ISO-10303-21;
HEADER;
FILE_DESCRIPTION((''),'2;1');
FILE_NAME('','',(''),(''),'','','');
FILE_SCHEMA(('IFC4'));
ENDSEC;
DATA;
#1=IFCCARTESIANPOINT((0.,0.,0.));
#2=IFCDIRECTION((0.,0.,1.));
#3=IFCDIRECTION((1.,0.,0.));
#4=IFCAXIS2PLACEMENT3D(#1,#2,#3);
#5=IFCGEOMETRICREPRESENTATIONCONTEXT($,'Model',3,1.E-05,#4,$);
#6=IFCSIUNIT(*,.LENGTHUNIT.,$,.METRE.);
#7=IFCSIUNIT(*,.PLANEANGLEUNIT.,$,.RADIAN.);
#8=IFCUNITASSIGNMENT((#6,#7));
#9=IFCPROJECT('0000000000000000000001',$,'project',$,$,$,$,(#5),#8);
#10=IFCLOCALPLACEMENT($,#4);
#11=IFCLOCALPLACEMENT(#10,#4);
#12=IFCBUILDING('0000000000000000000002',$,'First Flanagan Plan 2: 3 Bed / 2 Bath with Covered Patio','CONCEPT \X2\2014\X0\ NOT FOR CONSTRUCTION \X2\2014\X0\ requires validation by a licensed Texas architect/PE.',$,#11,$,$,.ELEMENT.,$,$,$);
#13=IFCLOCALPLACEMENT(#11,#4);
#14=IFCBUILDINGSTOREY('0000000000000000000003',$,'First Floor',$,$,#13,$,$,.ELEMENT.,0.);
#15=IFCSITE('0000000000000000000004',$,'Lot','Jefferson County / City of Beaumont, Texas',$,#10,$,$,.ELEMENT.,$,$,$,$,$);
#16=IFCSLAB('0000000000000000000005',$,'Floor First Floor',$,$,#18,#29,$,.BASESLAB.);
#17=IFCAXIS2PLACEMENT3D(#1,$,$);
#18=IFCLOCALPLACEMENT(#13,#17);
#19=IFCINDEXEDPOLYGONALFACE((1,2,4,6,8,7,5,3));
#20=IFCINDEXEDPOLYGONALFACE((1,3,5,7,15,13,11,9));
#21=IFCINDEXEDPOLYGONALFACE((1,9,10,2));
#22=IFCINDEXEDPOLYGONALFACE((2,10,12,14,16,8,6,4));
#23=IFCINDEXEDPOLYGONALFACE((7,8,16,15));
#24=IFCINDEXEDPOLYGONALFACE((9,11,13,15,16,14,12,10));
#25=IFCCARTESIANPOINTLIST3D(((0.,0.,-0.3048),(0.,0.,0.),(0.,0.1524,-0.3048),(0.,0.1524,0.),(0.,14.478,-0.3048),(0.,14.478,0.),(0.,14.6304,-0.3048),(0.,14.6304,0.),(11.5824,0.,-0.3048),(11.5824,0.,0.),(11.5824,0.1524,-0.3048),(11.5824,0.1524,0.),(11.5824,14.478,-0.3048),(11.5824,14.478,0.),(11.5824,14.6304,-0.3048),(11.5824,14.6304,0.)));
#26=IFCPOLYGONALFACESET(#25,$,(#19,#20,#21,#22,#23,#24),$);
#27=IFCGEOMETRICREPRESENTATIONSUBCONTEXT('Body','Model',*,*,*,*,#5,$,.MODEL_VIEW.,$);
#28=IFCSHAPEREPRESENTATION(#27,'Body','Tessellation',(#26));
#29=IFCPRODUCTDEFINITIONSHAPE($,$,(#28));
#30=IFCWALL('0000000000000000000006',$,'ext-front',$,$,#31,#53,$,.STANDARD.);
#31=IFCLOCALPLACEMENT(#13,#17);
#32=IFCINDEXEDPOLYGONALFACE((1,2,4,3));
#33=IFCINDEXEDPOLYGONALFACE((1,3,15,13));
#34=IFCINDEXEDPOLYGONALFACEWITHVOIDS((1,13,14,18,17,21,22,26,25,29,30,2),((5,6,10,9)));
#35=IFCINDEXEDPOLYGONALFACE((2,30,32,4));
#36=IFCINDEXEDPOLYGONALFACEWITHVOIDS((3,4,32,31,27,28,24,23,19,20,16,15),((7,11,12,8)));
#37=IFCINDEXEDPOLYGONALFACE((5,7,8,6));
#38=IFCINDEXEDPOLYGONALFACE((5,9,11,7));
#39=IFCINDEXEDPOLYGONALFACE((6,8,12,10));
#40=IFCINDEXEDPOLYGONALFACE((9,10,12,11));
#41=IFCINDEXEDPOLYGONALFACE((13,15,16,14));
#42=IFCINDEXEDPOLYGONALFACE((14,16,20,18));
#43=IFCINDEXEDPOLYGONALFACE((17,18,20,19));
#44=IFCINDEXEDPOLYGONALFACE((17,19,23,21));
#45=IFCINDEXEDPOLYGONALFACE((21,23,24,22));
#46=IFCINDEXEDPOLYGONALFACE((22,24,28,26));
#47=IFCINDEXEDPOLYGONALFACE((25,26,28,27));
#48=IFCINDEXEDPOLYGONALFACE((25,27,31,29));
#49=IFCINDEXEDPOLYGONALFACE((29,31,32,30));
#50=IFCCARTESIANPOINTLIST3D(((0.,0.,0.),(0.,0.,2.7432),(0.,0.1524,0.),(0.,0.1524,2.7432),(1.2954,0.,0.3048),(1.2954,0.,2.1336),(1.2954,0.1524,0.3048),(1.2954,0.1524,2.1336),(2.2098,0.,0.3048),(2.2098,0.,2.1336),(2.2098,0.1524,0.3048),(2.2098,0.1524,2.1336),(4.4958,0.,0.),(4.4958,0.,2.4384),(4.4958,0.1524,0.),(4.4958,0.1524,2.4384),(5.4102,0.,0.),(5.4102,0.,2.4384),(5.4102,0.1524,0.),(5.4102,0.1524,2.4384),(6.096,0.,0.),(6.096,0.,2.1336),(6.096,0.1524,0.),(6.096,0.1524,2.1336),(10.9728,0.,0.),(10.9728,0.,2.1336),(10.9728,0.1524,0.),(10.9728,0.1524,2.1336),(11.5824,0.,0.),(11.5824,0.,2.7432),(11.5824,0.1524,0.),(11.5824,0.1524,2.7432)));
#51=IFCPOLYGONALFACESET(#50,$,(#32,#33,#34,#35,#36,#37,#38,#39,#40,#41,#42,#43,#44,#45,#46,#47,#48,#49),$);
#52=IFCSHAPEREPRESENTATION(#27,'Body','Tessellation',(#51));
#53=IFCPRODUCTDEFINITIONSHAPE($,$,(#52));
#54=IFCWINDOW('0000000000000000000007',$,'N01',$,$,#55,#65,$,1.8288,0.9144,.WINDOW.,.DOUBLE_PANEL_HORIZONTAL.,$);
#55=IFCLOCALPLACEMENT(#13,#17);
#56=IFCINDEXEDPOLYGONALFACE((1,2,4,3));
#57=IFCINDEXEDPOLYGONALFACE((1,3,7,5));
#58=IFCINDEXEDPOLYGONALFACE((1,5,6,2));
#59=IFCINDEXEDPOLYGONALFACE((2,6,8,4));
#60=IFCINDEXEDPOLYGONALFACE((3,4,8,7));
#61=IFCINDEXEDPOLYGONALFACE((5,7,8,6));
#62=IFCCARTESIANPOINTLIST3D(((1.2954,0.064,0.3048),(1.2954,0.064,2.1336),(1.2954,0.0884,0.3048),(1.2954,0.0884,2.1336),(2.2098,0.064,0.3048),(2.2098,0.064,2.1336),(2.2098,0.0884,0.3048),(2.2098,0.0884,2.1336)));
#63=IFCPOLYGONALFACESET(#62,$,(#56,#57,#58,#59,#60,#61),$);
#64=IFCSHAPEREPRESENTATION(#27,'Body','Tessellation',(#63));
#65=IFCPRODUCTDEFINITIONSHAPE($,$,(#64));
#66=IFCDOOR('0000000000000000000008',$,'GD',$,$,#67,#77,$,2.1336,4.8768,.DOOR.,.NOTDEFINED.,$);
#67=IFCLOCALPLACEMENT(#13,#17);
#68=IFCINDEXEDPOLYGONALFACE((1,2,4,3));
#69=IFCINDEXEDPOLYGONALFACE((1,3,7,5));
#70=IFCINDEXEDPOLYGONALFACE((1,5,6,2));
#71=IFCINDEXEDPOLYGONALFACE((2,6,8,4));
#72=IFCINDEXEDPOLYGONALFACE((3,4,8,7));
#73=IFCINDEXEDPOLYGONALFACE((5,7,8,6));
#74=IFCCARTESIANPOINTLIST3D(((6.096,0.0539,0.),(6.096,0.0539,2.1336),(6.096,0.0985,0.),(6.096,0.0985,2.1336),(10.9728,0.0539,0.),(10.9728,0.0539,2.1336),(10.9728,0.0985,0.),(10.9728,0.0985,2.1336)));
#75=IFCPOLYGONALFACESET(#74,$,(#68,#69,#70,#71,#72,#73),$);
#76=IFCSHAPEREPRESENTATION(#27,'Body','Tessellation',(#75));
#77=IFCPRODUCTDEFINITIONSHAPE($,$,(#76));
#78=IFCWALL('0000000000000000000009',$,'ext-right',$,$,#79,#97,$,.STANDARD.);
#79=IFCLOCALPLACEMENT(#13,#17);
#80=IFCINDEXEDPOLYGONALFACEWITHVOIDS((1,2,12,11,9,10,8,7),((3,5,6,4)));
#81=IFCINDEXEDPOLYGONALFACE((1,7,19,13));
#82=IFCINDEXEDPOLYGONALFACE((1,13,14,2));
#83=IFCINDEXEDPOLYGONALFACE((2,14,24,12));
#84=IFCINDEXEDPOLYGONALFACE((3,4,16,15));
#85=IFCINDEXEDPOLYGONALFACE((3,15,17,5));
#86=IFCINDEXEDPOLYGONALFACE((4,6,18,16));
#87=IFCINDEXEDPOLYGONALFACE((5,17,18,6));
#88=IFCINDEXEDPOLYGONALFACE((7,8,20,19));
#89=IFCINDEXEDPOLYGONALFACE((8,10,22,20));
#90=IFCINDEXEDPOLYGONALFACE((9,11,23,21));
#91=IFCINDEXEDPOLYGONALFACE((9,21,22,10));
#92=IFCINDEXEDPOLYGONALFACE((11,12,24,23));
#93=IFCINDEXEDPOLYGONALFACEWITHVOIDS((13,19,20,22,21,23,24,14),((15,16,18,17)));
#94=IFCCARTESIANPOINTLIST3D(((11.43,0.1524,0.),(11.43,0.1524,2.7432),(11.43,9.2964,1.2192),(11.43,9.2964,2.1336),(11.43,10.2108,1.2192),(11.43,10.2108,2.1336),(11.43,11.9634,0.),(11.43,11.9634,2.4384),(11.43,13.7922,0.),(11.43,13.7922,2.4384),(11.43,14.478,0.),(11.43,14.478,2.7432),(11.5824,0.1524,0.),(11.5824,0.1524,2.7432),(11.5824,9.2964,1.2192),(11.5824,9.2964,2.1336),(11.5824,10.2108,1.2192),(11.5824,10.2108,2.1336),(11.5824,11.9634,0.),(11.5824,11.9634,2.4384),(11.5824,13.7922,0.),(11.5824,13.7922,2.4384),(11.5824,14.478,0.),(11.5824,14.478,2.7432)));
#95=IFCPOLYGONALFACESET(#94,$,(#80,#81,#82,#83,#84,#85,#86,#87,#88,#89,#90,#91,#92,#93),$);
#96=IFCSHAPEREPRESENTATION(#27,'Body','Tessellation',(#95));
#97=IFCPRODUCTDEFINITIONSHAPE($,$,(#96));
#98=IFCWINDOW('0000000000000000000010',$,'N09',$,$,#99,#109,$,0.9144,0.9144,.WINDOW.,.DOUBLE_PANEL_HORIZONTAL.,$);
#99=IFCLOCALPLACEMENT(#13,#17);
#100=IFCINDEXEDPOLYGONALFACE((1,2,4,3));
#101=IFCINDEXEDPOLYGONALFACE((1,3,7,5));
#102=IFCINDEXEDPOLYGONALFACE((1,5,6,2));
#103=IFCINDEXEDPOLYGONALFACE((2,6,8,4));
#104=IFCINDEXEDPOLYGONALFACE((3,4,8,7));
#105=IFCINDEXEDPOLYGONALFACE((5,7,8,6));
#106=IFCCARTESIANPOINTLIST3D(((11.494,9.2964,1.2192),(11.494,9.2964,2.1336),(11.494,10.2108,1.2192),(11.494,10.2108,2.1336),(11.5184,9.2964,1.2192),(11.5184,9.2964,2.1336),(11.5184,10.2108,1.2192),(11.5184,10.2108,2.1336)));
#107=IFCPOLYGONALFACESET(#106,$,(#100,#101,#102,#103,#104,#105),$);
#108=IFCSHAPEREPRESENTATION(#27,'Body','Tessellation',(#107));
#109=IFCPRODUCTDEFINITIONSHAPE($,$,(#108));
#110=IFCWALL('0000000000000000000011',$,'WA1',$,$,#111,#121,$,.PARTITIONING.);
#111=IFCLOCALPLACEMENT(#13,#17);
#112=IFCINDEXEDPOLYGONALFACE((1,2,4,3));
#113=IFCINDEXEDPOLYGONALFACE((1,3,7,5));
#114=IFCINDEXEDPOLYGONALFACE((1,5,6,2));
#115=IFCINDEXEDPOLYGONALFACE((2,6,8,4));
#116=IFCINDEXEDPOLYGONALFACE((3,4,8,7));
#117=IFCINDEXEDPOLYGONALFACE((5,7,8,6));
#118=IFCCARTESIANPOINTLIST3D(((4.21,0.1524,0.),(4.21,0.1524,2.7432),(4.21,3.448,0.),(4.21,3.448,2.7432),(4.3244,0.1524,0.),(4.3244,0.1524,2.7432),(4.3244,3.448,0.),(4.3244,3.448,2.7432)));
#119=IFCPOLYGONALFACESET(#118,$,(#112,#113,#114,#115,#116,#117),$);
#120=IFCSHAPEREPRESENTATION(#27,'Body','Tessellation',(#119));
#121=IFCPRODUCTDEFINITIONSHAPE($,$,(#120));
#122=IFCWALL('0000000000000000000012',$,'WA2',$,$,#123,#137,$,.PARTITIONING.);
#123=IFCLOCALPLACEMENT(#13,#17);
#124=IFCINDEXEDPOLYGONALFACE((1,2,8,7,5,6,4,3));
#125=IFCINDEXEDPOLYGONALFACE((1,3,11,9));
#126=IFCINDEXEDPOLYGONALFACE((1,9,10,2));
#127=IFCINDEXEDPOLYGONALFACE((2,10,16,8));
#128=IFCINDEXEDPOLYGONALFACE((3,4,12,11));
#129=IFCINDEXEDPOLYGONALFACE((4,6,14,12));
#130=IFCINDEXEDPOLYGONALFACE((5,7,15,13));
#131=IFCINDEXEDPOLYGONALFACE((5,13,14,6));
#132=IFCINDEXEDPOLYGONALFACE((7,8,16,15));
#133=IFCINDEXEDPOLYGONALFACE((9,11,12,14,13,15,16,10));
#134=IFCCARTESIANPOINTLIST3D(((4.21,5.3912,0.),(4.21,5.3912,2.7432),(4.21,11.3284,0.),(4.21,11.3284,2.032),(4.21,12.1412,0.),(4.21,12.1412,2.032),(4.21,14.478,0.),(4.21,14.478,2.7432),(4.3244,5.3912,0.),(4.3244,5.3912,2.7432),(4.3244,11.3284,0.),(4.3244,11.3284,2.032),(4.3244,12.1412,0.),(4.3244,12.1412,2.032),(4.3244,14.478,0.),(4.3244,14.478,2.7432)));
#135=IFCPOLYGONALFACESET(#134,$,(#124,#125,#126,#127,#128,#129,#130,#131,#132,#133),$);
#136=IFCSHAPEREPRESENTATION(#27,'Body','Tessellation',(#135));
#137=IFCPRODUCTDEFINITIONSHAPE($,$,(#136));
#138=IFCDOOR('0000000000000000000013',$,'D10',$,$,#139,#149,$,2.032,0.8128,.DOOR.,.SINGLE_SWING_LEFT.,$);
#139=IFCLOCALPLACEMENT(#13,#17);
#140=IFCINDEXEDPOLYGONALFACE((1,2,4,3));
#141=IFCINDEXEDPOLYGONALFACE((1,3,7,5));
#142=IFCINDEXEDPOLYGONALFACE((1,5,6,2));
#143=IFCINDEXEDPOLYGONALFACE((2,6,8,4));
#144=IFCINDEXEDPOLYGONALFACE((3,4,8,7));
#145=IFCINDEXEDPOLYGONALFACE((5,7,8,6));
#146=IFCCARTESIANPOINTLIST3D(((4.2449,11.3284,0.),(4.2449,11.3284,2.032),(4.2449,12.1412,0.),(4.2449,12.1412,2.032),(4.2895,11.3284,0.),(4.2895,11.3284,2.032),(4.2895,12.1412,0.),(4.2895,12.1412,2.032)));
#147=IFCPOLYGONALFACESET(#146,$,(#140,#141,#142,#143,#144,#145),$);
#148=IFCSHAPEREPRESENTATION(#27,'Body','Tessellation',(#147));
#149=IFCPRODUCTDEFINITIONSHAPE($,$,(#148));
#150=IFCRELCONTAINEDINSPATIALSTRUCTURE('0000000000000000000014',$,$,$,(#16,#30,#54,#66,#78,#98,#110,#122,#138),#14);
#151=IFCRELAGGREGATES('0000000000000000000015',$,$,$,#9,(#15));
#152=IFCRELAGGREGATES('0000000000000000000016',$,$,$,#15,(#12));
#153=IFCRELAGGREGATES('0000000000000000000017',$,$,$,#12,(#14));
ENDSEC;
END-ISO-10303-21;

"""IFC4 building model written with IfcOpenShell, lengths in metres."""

from ifc_helpers import new_model, si_unit, frame, frame_2d, origin_with_axes, place, context, subcontext, project, spatial, polyline, rectangle, outline, extrude, element, fill, save


model = new_model("IFC4")

# Units and contexts
model_context = context("Model", 3, precision=1e-05, world=origin_with_axes())
body_context = subcontext(model_context, "Body", "Model", "MODEL_VIEW")
ifc_project = project(units=[si_unit("LENGTHUNIT", "METRE"), si_unit("PLANEANGLEUNIT", "RADIAN")], contexts=[model_context])

# Site, building, storey
site_placement = place(None, origin_with_axes())
site = spatial("IfcSite", under=ifc_project, at=site_placement, Name="Lot", Description="Jefferson County / City of Beaumont, Texas", CompositionType="ELEMENT")
building_placement = place(site_placement, origin_with_axes())
building = spatial("IfcBuilding", under=site, at=building_placement, Name="First Flanagan Plan 2: 3 Bed / 2 Bath with Covered Patio", Description="CONCEPT — NOT FOR CONSTRUCTION — requires validation by a licensed Texas architect/PE.", CompositionType="ELEMENT")
storey_placement = place(building_placement, origin_with_axes())
storey = spatial("IfcBuildingStorey", under=building, at=storey_placement, Name="First Floor", CompositionType="ELEMENT", Elevation=0.0)

# Slab
slab_placement = place(storey_placement, frame((0.0, 0.0, -0.3048), z_axis=(0.0, 0.0, 1.0), x_axis=(1.0, 0.0, 0.0)))
element("IfcSlab", 1, at=slab_placement, inside=storey, Name="Floor First Floor", PredefinedType="BASESLAB", context=body_context, shape_type="SweptSolid", body=[
    extrude(outline(polyline([(11.5824, 0.1524), (11.5824, 0.0), (0.0, 0.0), (0.0, 0.1524), (0.0, 14.478), (0.0, 14.6304), (11.5824, 14.6304), (11.5824, 14.478), (11.5824, 0.1524)])), origin_with_axes(), (0.0, 0.0, 1.0), 0.3048),
])

# Wall, openings, window, door
wall_1_placement = place(storey_placement, frame((0.0, 0.0762, 0.0), z_axis=(0.0, 0.0, 1.0), x_axis=(1.0, 0.0, 0.0)))
wall_1 = element("IfcWall", 2, at=wall_1_placement, inside=storey, Name="ext-front", PredefinedType="STANDARD", context=body_context, shape_type="SweptSolid", body=[
    extrude(rectangle(XDim=11.5824, YDim=0.1524, at=frame_2d((5.7912, 0.0), x_axis=(1.0, 0.0))), origin_with_axes(), (0.0, 0.0, 1.0), 2.7432),
])
opening_1_placement = place(wall_1_placement, frame((1.2954, 0.0, 0.3048), z_axis=(0.0, 0.0, 1.0), x_axis=(1.0, 0.0, 0.0)))
opening_1 = element("IfcOpeningElement", 3, at=opening_1_placement, cuts=wall_1, PredefinedType="OPENING", context=body_context, shape_type="SweptSolid", body=[
    extrude(rectangle(XDim=0.9144, YDim=0.1829, at=frame_2d((0.4572, 0.0), x_axis=(1.0, 0.0))), origin_with_axes(), (0.0, 0.0, 1.0), 1.8288),
])
opening_2_placement = place(wall_1_placement, frame((4.4958, 0.0, 0.0), z_axis=(0.0, 0.0, 1.0), x_axis=(1.0, 0.0, 0.0)))
element("IfcOpeningElement", 4, at=opening_2_placement, cuts=wall_1, PredefinedType="OPENING", context=body_context, shape_type="SweptSolid", body=[
    extrude(rectangle(XDim=0.9144, YDim=0.1829, at=frame_2d((0.4572, 0.0), x_axis=(1.0, 0.0))), origin_with_axes(), (0.0, 0.0, 1.0), 2.4384),
])
opening_3_placement = place(wall_1_placement, frame((6.096, 0.0, 0.0), z_axis=(0.0, 0.0, 1.0), x_axis=(1.0, 0.0, 0.0)))
opening_3 = element("IfcOpeningElement", 5, at=opening_3_placement, cuts=wall_1, PredefinedType="OPENING", context=body_context, shape_type="SweptSolid", body=[
    extrude(rectangle(XDim=4.8768, YDim=0.1829, at=frame_2d((2.4384, 0.0), x_axis=(1.0, 0.0))), origin_with_axes(), (0.0, 0.0, 1.0), 2.1336),
])
window_1_placement = place(opening_1_placement, origin_with_axes())
window_1 = element("IfcWindow", 6, at=window_1_placement, inside=storey, Name="N01", OverallHeight=1.8288, OverallWidth=0.9144, PartitioningType="DOUBLE_PANEL_HORIZONTAL", PredefinedType="WINDOW", context=body_context, shape_type="SweptSolid", body=[
    extrude(rectangle(XDim=0.9144, YDim=0.0244, at=frame_2d((0.4572, 0.0), x_axis=(1.0, 0.0))), origin_with_axes(), (0.0, 0.0, 1.0), 1.8288),
])
fill(opening_1, window_1)
door_1_placement = place(opening_3_placement, origin_with_axes())
door_1 = element("IfcDoor", 7, at=door_1_placement, inside=storey, Name="GD", OperationType="NOTDEFINED", OverallHeight=2.1336, OverallWidth=4.8768, PredefinedType="DOOR", context=body_context, shape_type="SweptSolid", body=[
    extrude(rectangle(XDim=4.8768, YDim=0.0445, at=frame_2d((2.4384, 0.0), x_axis=(1.0, 0.0))), origin_with_axes(), (0.0, 0.0, 1.0), 2.1336),
])
fill(opening_3, door_1)

# Wall, openings, window
wall_2_placement = place(storey_placement, frame((11.5062, 0.1524, 0.0), z_axis=(0.0, 0.0, 1.0), x_axis=(0.0, 1.0, 0.0)))
wall_2 = element("IfcWall", 8, at=wall_2_placement, inside=storey, Name="ext-right", PredefinedType="STANDARD", context=body_context, shape_type="SweptSolid", body=[
    extrude(rectangle(XDim=14.3256, YDim=0.1524, at=frame_2d((7.1628, 0.0), x_axis=(1.0, 0.0))), origin_with_axes(), (0.0, 0.0, 1.0), 2.7432),
])
opening_4_placement = place(wall_2_placement, frame((9.144, 0.0, 1.2192), z_axis=(0.0, 0.0, 1.0), x_axis=(1.0, 0.0, 0.0)))
opening_4 = element("IfcOpeningElement", 9, at=opening_4_placement, cuts=wall_2, PredefinedType="OPENING", context=body_context, shape_type="SweptSolid", body=[
    extrude(rectangle(XDim=0.9144, YDim=0.1829, at=frame_2d((0.4572, 0.0), x_axis=(1.0, 0.0))), origin_with_axes(), (0.0, 0.0, 1.0), 0.9144),
])
opening_5_placement = place(wall_2_placement, frame((11.811, 0.0, 0.0), z_axis=(0.0, 0.0, 1.0), x_axis=(1.0, 0.0, 0.0)))
element("IfcOpeningElement", 10, at=opening_5_placement, cuts=wall_2, PredefinedType="OPENING", context=body_context, shape_type="SweptSolid", body=[
    extrude(rectangle(XDim=1.8288, YDim=0.1829, at=frame_2d((0.9144, 0.0), x_axis=(1.0, 0.0))), origin_with_axes(), (0.0, 0.0, 1.0), 2.4384),
])
window_2_placement = place(opening_4_placement, origin_with_axes())
window_2 = element("IfcWindow", 11, at=window_2_placement, inside=storey, Name="N09", OverallHeight=0.9144, OverallWidth=0.9144, PartitioningType="DOUBLE_PANEL_HORIZONTAL", PredefinedType="WINDOW", context=body_context, shape_type="SweptSolid", body=[
    extrude(rectangle(XDim=0.9144, YDim=0.0244, at=frame_2d((0.4572, 0.0), x_axis=(1.0, 0.0))), origin_with_axes(), (0.0, 0.0, 1.0), 0.9144),
])
fill(opening_4, window_2)

# Wall
wall_3_placement = place(storey_placement, frame((4.2672, 0.1524, 0.0), z_axis=(0.0, 0.0, 1.0), x_axis=(0.0, 1.0, 0.0)))
element("IfcWall", 12, at=wall_3_placement, inside=storey, Name="WA1", PredefinedType="PARTITIONING", context=body_context, shape_type="SweptSolid", body=[
    extrude(rectangle(XDim=3.2957, YDim=0.1143, at=frame_2d((1.6478, 0.0), x_axis=(1.0, 0.0))), origin_with_axes(), (0.0, 0.0, 1.0), 2.7432),
])

# Wall, opening, door
wall_4_placement = place(storey_placement, frame((4.2672, 5.3912, 0.0), z_axis=(0.0, 0.0, 1.0), x_axis=(0.0, 1.0, 0.0)))
wall_4 = element("IfcWall", 13, at=wall_4_placement, inside=storey, Name="WA2", PredefinedType="PARTITIONING", context=body_context, shape_type="SweptSolid", body=[
    extrude(rectangle(XDim=9.0869, YDim=0.1143, at=frame_2d((4.5434, 0.0), x_axis=(1.0, 0.0))), origin_with_axes(), (0.0, 0.0, 1.0), 2.7432),
])
opening_6_placement = place(wall_4_placement, frame((5.9372, 0.0, 0.0), z_axis=(0.0, 0.0, 1.0), x_axis=(1.0, 0.0, 0.0)))
opening_6 = element("IfcOpeningElement", 14, at=opening_6_placement, cuts=wall_4, PredefinedType="OPENING", context=body_context, shape_type="SweptSolid", body=[
    extrude(rectangle(XDim=0.8128, YDim=0.1448, at=frame_2d((0.4064, 0.0), x_axis=(1.0, 0.0))), origin_with_axes(), (0.0, 0.0, 1.0), 2.032),
])
door_2_placement = place(opening_6_placement, origin_with_axes())
door_2 = element("IfcDoor", 15, at=door_2_placement, inside=storey, Name="D10", OperationType="SINGLE_SWING_LEFT", OverallHeight=2.032, OverallWidth=0.8128, PredefinedType="DOOR", context=body_context, shape_type="SweptSolid", body=[
    extrude(rectangle(XDim=0.8128, YDim=0.0445, at=frame_2d((0.4064, 0.0), x_axis=(1.0, 0.0))), origin_with_axes(), (0.0, 0.0, 1.0), 2.032),
])
fill(opening_6, door_2)

save(model, "model.ifc")
